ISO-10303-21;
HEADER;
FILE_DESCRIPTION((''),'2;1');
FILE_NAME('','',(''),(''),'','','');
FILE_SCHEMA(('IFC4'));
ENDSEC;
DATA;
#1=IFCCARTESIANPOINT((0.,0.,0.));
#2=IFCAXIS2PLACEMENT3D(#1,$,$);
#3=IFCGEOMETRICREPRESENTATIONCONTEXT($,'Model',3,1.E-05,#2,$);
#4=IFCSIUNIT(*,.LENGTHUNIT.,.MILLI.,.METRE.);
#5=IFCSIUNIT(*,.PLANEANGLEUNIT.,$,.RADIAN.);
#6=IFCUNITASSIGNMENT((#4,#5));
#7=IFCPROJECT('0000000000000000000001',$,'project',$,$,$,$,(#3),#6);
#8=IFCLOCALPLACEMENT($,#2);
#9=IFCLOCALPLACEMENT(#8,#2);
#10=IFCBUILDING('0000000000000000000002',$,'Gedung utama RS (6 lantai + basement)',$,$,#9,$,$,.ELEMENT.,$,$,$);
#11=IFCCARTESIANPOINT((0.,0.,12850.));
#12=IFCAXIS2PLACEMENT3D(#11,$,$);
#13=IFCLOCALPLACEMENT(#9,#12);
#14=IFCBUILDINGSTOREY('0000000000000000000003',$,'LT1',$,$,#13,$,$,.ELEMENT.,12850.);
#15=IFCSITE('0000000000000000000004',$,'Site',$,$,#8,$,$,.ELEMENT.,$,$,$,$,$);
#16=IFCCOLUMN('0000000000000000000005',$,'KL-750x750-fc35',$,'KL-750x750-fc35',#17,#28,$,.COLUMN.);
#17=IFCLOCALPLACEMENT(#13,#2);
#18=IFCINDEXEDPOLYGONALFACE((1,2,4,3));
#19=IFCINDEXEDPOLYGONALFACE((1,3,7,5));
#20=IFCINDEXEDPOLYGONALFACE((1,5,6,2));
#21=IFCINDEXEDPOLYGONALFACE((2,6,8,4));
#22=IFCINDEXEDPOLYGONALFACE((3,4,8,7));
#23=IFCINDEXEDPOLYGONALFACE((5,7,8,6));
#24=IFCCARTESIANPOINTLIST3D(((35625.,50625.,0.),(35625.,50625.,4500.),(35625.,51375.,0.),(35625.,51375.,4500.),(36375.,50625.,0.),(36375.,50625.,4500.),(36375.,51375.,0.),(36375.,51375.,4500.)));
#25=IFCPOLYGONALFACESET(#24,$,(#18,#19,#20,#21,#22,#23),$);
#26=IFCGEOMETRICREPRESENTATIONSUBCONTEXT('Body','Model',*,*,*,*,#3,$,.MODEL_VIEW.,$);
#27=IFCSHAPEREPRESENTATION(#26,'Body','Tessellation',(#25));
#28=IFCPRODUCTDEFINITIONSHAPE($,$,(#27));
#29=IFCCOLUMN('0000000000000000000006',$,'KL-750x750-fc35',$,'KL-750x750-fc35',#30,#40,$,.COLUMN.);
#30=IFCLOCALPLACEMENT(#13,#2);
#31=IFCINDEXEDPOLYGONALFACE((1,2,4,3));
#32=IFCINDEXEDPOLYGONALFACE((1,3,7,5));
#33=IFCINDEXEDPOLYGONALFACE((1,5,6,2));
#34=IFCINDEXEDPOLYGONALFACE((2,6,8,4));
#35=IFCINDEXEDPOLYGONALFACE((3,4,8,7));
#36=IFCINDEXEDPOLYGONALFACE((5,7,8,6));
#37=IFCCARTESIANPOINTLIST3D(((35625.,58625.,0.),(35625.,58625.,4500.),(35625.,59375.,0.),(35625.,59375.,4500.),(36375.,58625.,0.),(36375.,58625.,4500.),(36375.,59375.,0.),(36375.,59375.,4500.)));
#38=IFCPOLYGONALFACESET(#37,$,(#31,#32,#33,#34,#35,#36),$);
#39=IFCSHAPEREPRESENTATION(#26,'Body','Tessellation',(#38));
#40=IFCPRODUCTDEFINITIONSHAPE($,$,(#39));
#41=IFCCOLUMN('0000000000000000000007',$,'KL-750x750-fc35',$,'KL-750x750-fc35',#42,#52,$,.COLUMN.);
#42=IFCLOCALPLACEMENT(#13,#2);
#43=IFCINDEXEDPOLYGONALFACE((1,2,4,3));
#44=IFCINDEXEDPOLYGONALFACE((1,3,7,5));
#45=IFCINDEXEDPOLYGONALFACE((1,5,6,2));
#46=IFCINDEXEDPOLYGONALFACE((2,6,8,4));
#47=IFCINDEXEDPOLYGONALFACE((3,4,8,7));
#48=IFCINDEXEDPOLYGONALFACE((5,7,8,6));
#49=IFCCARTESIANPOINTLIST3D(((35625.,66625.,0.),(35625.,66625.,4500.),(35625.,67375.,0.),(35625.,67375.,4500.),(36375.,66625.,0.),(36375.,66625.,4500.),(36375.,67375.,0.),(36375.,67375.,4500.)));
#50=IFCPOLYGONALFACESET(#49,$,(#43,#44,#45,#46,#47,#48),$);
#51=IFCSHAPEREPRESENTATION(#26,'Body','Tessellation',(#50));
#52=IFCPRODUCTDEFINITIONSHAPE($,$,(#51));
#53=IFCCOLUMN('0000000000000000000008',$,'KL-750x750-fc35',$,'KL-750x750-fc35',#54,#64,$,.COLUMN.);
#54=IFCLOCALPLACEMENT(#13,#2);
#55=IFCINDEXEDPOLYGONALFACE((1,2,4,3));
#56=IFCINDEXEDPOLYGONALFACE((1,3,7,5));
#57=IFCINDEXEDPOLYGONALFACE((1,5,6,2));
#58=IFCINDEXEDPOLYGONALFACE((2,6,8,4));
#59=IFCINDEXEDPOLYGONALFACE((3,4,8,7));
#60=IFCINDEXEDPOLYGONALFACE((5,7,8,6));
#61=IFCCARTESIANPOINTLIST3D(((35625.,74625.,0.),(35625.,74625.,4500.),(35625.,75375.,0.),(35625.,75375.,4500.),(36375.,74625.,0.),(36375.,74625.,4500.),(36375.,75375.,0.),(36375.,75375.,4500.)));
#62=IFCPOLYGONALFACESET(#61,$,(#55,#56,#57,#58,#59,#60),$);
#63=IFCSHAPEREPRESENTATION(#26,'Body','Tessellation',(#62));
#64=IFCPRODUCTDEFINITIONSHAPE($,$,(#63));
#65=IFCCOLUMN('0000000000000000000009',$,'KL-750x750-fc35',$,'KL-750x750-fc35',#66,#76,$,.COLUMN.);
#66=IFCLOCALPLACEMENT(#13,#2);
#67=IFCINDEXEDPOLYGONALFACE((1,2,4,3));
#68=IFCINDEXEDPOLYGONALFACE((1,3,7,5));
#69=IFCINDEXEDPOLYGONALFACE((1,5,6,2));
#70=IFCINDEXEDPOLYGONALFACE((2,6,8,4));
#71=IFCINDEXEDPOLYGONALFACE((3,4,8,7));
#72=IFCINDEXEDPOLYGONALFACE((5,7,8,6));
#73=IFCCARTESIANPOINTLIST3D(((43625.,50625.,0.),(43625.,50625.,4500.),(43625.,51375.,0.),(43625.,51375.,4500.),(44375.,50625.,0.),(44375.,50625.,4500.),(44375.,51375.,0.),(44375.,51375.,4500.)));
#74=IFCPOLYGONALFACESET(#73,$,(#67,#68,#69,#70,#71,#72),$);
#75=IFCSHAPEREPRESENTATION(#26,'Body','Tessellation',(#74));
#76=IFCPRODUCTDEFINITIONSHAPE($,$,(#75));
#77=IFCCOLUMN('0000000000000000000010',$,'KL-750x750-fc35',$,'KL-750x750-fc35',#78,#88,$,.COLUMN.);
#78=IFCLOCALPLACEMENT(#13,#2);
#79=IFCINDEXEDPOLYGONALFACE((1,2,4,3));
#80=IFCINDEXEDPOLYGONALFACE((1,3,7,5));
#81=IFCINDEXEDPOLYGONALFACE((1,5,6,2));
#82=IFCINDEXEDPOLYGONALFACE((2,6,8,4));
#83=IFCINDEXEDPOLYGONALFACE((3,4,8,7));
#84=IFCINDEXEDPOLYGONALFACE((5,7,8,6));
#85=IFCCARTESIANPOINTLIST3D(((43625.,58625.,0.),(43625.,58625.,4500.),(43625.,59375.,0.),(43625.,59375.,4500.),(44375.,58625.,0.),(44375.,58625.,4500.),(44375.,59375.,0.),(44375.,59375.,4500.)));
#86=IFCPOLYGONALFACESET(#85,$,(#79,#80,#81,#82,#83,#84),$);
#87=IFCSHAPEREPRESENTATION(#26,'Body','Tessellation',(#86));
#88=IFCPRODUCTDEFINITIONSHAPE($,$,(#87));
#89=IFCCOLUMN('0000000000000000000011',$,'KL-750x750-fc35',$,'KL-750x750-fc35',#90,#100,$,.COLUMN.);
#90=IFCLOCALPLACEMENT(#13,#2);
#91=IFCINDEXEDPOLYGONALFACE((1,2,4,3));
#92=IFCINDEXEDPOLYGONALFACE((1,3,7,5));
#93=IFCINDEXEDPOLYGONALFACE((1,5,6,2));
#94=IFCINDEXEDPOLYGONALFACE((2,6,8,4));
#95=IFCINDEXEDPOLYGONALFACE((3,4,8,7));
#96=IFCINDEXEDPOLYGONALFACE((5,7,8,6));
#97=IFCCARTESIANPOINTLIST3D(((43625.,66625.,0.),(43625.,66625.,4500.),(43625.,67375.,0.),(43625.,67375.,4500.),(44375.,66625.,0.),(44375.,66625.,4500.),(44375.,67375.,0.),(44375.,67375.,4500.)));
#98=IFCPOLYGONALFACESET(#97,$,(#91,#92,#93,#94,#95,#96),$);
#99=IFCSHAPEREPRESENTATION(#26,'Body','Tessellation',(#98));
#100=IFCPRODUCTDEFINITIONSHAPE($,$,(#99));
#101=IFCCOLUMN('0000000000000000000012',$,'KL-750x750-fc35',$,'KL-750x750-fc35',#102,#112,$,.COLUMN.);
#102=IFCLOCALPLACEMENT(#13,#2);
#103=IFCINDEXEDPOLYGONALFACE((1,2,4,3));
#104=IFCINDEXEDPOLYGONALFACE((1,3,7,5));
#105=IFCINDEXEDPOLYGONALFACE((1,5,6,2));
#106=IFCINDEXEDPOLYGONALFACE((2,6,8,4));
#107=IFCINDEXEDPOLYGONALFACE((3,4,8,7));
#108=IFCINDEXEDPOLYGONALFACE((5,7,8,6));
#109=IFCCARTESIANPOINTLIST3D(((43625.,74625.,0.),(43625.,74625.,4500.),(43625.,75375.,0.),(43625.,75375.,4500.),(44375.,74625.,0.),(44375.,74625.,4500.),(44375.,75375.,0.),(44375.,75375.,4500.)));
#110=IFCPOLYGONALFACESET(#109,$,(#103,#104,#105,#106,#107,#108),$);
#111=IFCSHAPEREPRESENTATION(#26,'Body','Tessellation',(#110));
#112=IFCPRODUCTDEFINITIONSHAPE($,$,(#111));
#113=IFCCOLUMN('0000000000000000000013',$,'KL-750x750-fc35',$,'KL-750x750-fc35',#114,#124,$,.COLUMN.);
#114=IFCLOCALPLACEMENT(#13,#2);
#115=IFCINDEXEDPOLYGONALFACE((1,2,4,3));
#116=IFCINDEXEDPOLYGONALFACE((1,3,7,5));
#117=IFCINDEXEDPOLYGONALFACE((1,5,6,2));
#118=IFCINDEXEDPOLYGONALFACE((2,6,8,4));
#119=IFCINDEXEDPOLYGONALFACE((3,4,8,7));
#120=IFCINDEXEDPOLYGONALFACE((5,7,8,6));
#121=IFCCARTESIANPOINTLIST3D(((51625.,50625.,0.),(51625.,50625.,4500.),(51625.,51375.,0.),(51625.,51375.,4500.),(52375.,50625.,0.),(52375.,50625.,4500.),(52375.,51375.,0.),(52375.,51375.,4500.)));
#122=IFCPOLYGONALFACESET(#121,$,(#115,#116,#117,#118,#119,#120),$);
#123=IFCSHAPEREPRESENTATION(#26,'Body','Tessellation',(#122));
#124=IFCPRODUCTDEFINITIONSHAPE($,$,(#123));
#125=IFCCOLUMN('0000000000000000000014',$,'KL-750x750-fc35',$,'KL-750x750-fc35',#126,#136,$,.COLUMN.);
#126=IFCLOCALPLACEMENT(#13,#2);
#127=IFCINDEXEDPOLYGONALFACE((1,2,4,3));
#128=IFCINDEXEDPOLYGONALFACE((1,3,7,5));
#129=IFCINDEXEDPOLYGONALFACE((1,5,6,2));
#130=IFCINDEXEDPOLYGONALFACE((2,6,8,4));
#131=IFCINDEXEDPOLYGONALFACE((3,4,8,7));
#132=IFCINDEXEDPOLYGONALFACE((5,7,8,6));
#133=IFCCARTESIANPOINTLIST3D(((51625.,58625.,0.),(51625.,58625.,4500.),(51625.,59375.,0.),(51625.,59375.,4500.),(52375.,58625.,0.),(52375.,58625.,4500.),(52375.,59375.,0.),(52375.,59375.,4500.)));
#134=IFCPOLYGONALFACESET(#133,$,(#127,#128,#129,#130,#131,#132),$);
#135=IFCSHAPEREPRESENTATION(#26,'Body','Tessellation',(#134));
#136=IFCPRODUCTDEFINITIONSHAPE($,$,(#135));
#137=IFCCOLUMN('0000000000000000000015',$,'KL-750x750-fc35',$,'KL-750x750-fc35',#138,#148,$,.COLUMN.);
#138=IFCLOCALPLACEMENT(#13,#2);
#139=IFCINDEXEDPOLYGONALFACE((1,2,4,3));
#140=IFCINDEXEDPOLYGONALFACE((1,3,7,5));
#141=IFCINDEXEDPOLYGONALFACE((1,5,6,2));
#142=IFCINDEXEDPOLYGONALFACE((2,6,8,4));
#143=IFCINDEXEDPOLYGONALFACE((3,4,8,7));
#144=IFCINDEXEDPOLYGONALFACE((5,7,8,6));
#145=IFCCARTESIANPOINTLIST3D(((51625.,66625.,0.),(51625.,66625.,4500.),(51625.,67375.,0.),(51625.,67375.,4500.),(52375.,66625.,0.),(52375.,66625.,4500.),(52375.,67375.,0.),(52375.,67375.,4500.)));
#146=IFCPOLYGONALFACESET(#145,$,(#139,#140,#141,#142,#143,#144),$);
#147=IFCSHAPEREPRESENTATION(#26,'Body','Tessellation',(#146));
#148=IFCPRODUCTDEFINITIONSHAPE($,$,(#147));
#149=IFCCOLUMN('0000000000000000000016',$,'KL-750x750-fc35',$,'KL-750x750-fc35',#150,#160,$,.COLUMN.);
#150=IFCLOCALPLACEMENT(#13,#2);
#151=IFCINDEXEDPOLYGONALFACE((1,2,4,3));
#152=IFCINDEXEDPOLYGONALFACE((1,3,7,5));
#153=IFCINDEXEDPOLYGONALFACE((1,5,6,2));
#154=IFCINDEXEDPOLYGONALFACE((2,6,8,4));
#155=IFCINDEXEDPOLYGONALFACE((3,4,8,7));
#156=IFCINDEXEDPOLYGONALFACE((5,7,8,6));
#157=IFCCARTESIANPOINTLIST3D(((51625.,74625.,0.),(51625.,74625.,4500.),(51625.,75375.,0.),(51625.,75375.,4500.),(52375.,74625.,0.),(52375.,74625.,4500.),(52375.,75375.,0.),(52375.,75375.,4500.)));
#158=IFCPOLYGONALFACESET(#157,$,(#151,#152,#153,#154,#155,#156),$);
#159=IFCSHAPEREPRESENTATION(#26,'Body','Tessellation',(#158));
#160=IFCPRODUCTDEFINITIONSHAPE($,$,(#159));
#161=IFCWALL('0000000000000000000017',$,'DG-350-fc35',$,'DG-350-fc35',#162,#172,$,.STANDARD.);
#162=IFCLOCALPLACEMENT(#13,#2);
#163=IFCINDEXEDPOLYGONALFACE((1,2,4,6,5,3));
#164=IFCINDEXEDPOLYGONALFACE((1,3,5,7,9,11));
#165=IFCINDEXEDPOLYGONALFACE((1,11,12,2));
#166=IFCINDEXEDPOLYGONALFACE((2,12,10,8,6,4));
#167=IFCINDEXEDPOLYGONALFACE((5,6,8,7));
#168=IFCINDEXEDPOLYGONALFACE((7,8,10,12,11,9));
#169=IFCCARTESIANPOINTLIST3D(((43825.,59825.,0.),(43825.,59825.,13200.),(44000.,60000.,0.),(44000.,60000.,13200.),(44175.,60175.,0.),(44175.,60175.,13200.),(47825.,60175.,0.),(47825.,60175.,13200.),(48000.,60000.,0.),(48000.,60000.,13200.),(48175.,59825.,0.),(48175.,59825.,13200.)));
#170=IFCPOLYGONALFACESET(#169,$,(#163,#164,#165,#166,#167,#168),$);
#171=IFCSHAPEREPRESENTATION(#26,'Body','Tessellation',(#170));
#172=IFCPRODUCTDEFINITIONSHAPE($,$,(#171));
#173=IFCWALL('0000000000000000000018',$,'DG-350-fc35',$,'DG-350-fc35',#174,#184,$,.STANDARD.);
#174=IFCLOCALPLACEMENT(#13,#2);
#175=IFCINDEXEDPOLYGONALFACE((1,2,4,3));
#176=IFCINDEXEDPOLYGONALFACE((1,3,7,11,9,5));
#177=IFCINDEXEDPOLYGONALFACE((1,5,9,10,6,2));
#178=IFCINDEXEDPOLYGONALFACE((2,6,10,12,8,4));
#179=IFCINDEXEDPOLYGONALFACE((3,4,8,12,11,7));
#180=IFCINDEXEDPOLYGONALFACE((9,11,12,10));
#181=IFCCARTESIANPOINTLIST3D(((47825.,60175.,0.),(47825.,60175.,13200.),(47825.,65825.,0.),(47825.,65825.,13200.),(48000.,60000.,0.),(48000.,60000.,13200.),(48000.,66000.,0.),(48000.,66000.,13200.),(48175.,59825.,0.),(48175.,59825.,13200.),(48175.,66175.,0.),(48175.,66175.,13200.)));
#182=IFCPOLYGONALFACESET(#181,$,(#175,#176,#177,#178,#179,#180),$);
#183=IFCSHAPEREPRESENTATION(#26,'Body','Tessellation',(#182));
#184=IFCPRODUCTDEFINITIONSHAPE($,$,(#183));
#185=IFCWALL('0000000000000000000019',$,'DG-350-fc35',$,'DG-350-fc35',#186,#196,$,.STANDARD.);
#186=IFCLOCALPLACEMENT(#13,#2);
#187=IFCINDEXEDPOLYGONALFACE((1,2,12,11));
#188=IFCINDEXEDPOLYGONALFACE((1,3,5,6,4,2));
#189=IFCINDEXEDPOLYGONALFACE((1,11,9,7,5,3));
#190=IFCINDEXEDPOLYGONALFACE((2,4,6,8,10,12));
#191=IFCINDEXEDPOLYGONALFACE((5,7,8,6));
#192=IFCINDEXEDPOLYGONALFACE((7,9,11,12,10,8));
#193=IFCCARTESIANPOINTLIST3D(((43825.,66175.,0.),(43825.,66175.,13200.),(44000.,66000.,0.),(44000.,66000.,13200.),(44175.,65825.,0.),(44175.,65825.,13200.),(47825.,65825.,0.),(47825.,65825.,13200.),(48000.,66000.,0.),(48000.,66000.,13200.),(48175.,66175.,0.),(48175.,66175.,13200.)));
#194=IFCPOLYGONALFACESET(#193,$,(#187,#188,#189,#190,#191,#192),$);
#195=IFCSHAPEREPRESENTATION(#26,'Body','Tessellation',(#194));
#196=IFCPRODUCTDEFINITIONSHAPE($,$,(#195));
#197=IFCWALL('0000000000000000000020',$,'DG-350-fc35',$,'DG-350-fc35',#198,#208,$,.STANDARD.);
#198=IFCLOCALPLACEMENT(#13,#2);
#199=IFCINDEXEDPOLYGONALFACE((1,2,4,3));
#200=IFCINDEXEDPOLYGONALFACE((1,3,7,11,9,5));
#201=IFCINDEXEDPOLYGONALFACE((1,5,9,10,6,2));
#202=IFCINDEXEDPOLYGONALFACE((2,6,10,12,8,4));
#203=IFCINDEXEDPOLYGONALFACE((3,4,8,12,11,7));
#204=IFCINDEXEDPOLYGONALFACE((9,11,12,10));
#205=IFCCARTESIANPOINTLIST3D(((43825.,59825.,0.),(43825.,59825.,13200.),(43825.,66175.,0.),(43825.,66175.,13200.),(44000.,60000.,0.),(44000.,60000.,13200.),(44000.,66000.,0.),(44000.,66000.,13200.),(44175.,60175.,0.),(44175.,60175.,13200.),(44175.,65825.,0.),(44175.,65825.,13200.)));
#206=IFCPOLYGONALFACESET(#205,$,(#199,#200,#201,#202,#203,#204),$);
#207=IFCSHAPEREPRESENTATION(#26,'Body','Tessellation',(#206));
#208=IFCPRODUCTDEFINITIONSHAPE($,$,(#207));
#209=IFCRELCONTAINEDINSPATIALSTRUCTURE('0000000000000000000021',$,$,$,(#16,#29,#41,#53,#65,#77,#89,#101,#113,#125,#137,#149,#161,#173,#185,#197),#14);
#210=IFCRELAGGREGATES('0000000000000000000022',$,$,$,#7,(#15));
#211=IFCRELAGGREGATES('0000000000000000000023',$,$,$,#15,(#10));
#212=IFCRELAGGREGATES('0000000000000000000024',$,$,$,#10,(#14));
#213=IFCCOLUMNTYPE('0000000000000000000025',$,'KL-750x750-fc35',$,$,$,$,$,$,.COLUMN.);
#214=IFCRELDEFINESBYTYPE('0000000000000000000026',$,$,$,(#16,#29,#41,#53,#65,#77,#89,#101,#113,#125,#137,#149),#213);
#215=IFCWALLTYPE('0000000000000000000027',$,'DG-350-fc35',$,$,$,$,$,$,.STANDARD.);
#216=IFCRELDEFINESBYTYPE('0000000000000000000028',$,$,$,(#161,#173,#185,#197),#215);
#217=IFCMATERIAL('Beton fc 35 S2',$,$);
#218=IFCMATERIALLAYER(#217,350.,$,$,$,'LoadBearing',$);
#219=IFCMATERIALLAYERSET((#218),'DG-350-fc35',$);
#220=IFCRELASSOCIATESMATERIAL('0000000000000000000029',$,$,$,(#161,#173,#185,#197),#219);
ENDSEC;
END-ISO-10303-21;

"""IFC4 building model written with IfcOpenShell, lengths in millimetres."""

from ifc_helpers import new_model, si_unit, frame, origin, origin_2d, place, context, subcontext, project, spatial, polyline, rectangle, outline, extrude, material, layer, layer_set, layer_usage, material_profile, profile_set, profile_usage, type_object, element, save


model = new_model("IFC4")

# Units and contexts
model_context = context("Model", 3, precision=1e-05, world=origin())
body_context = subcontext(model_context, "Body", "Model", "MODEL_VIEW")
ifc_project = project(units=[si_unit("LENGTHUNIT", "METRE", prefix="MILLI"), si_unit("PLANEANGLEUNIT", "RADIAN")], contexts=[model_context])

# Site, building, storey
site_placement = place(None, origin())
site = spatial("IfcSite", under=ifc_project, at=site_placement, Name="Site", CompositionType="ELEMENT")
building_placement = place(site_placement, origin())
building = spatial("IfcBuilding", under=site, at=building_placement, Name="Gedung utama RS (6 lantai + basement)", CompositionType="ELEMENT")
storey_placement = place(building_placement, frame((0.0, 0.0, 12850.0)))
storey = spatial("IfcBuildingStorey", under=building, at=storey_placement, Name="LT1", CompositionType="ELEMENT", Elevation=12850.0)

# Columns
ifc_material_profile_1 = material_profile(None, rectangle(XDim=750.0, YDim=750.0, at=origin_2d()), Name="KL-750x750-fc35")
ifc_profile_set_1 = profile_set([ifc_material_profile_1], Name="KL-750x750-fc35")
ifc_profile_usage_1 = profile_usage(ifc_profile_set_1, cardinal=5)
column_type = type_object("IfcColumnType", Name="KL-750x750-fc35", PredefinedType="COLUMN", material=ifc_profile_set_1)
for number, where, z_axis, x_axis, name in (
    (1, (36000.0, 51000.0, 0.0), (0.0, 0.0, 1.0), (1.0, 0.0, 0.0), "KL-750x750-fc35"),
    (2, (36000.0, 59000.0, 0.0), (0.0, 0.0, 1.0), (1.0, 0.0, 0.0), "KL-750x750-fc35"),
    (3, (36000.0, 67000.0, 0.0), (0.0, 0.0, 1.0), (1.0, 0.0, 0.0), "KL-750x750-fc35"),
    (4, (36000.0, 75000.0, 0.0), (0.0, 0.0, 1.0), (1.0, 0.0, 0.0), "KL-750x750-fc35"),
    (5, (44000.0, 51000.0, 0.0), (0.0, 0.0, 1.0), (1.0, 0.0, 0.0), "KL-750x750-fc35"),
    (6, (44000.0, 59000.0, 0.0), (0.0, 0.0, 1.0), (1.0, 0.0, 0.0), "KL-750x750-fc35"),
    (7, (44000.0, 67000.0, 0.0), (0.0, 0.0, 1.0), (1.0, 0.0, 0.0), "KL-750x750-fc35"),
    (8, (44000.0, 75000.0, 0.0), (0.0, 0.0, 1.0), (1.0, 0.0, 0.0), "KL-750x750-fc35"),
    (9, (52000.0, 51000.0, 0.0), (0.0, 0.0, 1.0), (1.0, 0.0, 0.0), "KL-750x750-fc35"),
    (10, (52000.0, 59000.0, 0.0), (0.0, 0.0, 1.0), (1.0, 0.0, 0.0), "KL-750x750-fc35"),
    (11, (52000.0, 67000.0, 0.0), (0.0, 0.0, 1.0), (1.0, 0.0, 0.0), "KL-750x750-fc35"),
    (12, (52000.0, 75000.0, 0.0), (0.0, 0.0, 1.0), (1.0, 0.0, 0.0), "KL-750x750-fc35"),
):
    element("IfcColumn", number, at=place(storey_placement, frame(where, z_axis=z_axis, x_axis=x_axis)), inside=storey, type_object=column_type, material=ifc_profile_usage_1, Name=name, ObjectType="KL-750x750-fc35", PredefinedType="COLUMN", context=body_context, shape_type="SweptSolid", body=[
        extrude(rectangle(XDim=750.0, YDim=750.0, at=origin_2d()), origin(), (0.0, 0.0, 1.0), 4500.0),
    ])

# Walls
ifc_material = material(Name="Beton fc 35 S2")
ifc_layer = layer(ifc_material, 350.0, Category="LoadBearing")
ifc_layer_set = layer_set([ifc_layer], Name="DG-350-fc35")
ifc_layer_usage = layer_usage(ifc_layer_set, "AXIS2", "NEGATIVE", 175.0)
wall_type = type_object("IfcWallType", Name="DG-350-fc35", PredefinedType="STANDARD")
wall_1_placement = place(storey_placement, frame((44000.0, 60000.0, 0.0), z_axis=(0.0, 0.0, 1.0), x_axis=(1.0, 0.0, 0.0)))
element("IfcWall", 13, at=wall_1_placement, inside=storey, type_object=wall_type, material=ifc_layer_usage, Name="DG-350-fc35", ObjectType="DG-350-fc35", PredefinedType="STANDARD", context=body_context, shape_type="SweptSolid", body=[
    extrude(outline(polyline([(-175.0, -175.0), (0.0, 0.0), (175.0, 175.0), (3825.0, 175.0), (4000.0, 0.0), (4175.0, -175.0), (-175.0, -175.0)])), origin(), (0.0, 0.0, 1.0), 13200.0),
])
wall_2_placement = place(storey_placement, frame((48000.0, 60000.0, 0.0), z_axis=(0.0, 0.0, 1.0), x_axis=(0.0, 1.0, 0.0)))
element("IfcWall", 14, at=wall_2_placement, inside=storey, type_object=wall_type, material=ifc_layer_usage, Name="DG-350-fc35", ObjectType="DG-350-fc35", PredefinedType="STANDARD", context=body_context, shape_type="SweptSolid", body=[
    extrude(outline(polyline([(-175.0, -175.0), (0.0, 0.0), (175.0, 175.0), (5825.0, 175.0), (6000.0, 0.0), (6175.0, -175.0), (-175.0, -175.0)])), origin(), (0.0, 0.0, 1.0), 13200.0),
])
wall_3_placement = place(storey_placement, frame((48000.0, 66000.0, 0.0), z_axis=(0.0, 0.0, 1.0), x_axis=(-1.0, 0.0, 0.0)))
element("IfcWall", 15, at=wall_3_placement, inside=storey, type_object=wall_type, material=ifc_layer_usage, Name="DG-350-fc35", ObjectType="DG-350-fc35", PredefinedType="STANDARD", context=body_context, shape_type="SweptSolid", body=[
    extrude(outline(polyline([(-175.0, -175.0), (0.0, 0.0), (175.0, 175.0), (3825.0, 175.0), (4000.0, 0.0), (4175.0, -175.0), (-175.0, -175.0)])), origin(), (0.0, 0.0, 1.0), 13200.0),
])
wall_4_placement = place(storey_placement, frame((44000.0, 66000.0, 0.0), z_axis=(0.0, 0.0, 1.0), x_axis=(0.0, -1.0, 0.0)))
element("IfcWall", 16, at=wall_4_placement, inside=storey, type_object=wall_type, material=ifc_layer_usage, Name="DG-350-fc35", ObjectType="DG-350-fc35", PredefinedType="STANDARD", context=body_context, shape_type="SweptSolid", body=[
    extrude(outline(polyline([(-175.0, -175.0), (0.0, 0.0), (175.0, 175.0), (5825.0, 175.0), (6000.0, 0.0), (6175.0, -175.0), (-175.0, -175.0)])), origin(), (0.0, 0.0, 1.0), 13200.0),
])

save(model, "model.ifc")
